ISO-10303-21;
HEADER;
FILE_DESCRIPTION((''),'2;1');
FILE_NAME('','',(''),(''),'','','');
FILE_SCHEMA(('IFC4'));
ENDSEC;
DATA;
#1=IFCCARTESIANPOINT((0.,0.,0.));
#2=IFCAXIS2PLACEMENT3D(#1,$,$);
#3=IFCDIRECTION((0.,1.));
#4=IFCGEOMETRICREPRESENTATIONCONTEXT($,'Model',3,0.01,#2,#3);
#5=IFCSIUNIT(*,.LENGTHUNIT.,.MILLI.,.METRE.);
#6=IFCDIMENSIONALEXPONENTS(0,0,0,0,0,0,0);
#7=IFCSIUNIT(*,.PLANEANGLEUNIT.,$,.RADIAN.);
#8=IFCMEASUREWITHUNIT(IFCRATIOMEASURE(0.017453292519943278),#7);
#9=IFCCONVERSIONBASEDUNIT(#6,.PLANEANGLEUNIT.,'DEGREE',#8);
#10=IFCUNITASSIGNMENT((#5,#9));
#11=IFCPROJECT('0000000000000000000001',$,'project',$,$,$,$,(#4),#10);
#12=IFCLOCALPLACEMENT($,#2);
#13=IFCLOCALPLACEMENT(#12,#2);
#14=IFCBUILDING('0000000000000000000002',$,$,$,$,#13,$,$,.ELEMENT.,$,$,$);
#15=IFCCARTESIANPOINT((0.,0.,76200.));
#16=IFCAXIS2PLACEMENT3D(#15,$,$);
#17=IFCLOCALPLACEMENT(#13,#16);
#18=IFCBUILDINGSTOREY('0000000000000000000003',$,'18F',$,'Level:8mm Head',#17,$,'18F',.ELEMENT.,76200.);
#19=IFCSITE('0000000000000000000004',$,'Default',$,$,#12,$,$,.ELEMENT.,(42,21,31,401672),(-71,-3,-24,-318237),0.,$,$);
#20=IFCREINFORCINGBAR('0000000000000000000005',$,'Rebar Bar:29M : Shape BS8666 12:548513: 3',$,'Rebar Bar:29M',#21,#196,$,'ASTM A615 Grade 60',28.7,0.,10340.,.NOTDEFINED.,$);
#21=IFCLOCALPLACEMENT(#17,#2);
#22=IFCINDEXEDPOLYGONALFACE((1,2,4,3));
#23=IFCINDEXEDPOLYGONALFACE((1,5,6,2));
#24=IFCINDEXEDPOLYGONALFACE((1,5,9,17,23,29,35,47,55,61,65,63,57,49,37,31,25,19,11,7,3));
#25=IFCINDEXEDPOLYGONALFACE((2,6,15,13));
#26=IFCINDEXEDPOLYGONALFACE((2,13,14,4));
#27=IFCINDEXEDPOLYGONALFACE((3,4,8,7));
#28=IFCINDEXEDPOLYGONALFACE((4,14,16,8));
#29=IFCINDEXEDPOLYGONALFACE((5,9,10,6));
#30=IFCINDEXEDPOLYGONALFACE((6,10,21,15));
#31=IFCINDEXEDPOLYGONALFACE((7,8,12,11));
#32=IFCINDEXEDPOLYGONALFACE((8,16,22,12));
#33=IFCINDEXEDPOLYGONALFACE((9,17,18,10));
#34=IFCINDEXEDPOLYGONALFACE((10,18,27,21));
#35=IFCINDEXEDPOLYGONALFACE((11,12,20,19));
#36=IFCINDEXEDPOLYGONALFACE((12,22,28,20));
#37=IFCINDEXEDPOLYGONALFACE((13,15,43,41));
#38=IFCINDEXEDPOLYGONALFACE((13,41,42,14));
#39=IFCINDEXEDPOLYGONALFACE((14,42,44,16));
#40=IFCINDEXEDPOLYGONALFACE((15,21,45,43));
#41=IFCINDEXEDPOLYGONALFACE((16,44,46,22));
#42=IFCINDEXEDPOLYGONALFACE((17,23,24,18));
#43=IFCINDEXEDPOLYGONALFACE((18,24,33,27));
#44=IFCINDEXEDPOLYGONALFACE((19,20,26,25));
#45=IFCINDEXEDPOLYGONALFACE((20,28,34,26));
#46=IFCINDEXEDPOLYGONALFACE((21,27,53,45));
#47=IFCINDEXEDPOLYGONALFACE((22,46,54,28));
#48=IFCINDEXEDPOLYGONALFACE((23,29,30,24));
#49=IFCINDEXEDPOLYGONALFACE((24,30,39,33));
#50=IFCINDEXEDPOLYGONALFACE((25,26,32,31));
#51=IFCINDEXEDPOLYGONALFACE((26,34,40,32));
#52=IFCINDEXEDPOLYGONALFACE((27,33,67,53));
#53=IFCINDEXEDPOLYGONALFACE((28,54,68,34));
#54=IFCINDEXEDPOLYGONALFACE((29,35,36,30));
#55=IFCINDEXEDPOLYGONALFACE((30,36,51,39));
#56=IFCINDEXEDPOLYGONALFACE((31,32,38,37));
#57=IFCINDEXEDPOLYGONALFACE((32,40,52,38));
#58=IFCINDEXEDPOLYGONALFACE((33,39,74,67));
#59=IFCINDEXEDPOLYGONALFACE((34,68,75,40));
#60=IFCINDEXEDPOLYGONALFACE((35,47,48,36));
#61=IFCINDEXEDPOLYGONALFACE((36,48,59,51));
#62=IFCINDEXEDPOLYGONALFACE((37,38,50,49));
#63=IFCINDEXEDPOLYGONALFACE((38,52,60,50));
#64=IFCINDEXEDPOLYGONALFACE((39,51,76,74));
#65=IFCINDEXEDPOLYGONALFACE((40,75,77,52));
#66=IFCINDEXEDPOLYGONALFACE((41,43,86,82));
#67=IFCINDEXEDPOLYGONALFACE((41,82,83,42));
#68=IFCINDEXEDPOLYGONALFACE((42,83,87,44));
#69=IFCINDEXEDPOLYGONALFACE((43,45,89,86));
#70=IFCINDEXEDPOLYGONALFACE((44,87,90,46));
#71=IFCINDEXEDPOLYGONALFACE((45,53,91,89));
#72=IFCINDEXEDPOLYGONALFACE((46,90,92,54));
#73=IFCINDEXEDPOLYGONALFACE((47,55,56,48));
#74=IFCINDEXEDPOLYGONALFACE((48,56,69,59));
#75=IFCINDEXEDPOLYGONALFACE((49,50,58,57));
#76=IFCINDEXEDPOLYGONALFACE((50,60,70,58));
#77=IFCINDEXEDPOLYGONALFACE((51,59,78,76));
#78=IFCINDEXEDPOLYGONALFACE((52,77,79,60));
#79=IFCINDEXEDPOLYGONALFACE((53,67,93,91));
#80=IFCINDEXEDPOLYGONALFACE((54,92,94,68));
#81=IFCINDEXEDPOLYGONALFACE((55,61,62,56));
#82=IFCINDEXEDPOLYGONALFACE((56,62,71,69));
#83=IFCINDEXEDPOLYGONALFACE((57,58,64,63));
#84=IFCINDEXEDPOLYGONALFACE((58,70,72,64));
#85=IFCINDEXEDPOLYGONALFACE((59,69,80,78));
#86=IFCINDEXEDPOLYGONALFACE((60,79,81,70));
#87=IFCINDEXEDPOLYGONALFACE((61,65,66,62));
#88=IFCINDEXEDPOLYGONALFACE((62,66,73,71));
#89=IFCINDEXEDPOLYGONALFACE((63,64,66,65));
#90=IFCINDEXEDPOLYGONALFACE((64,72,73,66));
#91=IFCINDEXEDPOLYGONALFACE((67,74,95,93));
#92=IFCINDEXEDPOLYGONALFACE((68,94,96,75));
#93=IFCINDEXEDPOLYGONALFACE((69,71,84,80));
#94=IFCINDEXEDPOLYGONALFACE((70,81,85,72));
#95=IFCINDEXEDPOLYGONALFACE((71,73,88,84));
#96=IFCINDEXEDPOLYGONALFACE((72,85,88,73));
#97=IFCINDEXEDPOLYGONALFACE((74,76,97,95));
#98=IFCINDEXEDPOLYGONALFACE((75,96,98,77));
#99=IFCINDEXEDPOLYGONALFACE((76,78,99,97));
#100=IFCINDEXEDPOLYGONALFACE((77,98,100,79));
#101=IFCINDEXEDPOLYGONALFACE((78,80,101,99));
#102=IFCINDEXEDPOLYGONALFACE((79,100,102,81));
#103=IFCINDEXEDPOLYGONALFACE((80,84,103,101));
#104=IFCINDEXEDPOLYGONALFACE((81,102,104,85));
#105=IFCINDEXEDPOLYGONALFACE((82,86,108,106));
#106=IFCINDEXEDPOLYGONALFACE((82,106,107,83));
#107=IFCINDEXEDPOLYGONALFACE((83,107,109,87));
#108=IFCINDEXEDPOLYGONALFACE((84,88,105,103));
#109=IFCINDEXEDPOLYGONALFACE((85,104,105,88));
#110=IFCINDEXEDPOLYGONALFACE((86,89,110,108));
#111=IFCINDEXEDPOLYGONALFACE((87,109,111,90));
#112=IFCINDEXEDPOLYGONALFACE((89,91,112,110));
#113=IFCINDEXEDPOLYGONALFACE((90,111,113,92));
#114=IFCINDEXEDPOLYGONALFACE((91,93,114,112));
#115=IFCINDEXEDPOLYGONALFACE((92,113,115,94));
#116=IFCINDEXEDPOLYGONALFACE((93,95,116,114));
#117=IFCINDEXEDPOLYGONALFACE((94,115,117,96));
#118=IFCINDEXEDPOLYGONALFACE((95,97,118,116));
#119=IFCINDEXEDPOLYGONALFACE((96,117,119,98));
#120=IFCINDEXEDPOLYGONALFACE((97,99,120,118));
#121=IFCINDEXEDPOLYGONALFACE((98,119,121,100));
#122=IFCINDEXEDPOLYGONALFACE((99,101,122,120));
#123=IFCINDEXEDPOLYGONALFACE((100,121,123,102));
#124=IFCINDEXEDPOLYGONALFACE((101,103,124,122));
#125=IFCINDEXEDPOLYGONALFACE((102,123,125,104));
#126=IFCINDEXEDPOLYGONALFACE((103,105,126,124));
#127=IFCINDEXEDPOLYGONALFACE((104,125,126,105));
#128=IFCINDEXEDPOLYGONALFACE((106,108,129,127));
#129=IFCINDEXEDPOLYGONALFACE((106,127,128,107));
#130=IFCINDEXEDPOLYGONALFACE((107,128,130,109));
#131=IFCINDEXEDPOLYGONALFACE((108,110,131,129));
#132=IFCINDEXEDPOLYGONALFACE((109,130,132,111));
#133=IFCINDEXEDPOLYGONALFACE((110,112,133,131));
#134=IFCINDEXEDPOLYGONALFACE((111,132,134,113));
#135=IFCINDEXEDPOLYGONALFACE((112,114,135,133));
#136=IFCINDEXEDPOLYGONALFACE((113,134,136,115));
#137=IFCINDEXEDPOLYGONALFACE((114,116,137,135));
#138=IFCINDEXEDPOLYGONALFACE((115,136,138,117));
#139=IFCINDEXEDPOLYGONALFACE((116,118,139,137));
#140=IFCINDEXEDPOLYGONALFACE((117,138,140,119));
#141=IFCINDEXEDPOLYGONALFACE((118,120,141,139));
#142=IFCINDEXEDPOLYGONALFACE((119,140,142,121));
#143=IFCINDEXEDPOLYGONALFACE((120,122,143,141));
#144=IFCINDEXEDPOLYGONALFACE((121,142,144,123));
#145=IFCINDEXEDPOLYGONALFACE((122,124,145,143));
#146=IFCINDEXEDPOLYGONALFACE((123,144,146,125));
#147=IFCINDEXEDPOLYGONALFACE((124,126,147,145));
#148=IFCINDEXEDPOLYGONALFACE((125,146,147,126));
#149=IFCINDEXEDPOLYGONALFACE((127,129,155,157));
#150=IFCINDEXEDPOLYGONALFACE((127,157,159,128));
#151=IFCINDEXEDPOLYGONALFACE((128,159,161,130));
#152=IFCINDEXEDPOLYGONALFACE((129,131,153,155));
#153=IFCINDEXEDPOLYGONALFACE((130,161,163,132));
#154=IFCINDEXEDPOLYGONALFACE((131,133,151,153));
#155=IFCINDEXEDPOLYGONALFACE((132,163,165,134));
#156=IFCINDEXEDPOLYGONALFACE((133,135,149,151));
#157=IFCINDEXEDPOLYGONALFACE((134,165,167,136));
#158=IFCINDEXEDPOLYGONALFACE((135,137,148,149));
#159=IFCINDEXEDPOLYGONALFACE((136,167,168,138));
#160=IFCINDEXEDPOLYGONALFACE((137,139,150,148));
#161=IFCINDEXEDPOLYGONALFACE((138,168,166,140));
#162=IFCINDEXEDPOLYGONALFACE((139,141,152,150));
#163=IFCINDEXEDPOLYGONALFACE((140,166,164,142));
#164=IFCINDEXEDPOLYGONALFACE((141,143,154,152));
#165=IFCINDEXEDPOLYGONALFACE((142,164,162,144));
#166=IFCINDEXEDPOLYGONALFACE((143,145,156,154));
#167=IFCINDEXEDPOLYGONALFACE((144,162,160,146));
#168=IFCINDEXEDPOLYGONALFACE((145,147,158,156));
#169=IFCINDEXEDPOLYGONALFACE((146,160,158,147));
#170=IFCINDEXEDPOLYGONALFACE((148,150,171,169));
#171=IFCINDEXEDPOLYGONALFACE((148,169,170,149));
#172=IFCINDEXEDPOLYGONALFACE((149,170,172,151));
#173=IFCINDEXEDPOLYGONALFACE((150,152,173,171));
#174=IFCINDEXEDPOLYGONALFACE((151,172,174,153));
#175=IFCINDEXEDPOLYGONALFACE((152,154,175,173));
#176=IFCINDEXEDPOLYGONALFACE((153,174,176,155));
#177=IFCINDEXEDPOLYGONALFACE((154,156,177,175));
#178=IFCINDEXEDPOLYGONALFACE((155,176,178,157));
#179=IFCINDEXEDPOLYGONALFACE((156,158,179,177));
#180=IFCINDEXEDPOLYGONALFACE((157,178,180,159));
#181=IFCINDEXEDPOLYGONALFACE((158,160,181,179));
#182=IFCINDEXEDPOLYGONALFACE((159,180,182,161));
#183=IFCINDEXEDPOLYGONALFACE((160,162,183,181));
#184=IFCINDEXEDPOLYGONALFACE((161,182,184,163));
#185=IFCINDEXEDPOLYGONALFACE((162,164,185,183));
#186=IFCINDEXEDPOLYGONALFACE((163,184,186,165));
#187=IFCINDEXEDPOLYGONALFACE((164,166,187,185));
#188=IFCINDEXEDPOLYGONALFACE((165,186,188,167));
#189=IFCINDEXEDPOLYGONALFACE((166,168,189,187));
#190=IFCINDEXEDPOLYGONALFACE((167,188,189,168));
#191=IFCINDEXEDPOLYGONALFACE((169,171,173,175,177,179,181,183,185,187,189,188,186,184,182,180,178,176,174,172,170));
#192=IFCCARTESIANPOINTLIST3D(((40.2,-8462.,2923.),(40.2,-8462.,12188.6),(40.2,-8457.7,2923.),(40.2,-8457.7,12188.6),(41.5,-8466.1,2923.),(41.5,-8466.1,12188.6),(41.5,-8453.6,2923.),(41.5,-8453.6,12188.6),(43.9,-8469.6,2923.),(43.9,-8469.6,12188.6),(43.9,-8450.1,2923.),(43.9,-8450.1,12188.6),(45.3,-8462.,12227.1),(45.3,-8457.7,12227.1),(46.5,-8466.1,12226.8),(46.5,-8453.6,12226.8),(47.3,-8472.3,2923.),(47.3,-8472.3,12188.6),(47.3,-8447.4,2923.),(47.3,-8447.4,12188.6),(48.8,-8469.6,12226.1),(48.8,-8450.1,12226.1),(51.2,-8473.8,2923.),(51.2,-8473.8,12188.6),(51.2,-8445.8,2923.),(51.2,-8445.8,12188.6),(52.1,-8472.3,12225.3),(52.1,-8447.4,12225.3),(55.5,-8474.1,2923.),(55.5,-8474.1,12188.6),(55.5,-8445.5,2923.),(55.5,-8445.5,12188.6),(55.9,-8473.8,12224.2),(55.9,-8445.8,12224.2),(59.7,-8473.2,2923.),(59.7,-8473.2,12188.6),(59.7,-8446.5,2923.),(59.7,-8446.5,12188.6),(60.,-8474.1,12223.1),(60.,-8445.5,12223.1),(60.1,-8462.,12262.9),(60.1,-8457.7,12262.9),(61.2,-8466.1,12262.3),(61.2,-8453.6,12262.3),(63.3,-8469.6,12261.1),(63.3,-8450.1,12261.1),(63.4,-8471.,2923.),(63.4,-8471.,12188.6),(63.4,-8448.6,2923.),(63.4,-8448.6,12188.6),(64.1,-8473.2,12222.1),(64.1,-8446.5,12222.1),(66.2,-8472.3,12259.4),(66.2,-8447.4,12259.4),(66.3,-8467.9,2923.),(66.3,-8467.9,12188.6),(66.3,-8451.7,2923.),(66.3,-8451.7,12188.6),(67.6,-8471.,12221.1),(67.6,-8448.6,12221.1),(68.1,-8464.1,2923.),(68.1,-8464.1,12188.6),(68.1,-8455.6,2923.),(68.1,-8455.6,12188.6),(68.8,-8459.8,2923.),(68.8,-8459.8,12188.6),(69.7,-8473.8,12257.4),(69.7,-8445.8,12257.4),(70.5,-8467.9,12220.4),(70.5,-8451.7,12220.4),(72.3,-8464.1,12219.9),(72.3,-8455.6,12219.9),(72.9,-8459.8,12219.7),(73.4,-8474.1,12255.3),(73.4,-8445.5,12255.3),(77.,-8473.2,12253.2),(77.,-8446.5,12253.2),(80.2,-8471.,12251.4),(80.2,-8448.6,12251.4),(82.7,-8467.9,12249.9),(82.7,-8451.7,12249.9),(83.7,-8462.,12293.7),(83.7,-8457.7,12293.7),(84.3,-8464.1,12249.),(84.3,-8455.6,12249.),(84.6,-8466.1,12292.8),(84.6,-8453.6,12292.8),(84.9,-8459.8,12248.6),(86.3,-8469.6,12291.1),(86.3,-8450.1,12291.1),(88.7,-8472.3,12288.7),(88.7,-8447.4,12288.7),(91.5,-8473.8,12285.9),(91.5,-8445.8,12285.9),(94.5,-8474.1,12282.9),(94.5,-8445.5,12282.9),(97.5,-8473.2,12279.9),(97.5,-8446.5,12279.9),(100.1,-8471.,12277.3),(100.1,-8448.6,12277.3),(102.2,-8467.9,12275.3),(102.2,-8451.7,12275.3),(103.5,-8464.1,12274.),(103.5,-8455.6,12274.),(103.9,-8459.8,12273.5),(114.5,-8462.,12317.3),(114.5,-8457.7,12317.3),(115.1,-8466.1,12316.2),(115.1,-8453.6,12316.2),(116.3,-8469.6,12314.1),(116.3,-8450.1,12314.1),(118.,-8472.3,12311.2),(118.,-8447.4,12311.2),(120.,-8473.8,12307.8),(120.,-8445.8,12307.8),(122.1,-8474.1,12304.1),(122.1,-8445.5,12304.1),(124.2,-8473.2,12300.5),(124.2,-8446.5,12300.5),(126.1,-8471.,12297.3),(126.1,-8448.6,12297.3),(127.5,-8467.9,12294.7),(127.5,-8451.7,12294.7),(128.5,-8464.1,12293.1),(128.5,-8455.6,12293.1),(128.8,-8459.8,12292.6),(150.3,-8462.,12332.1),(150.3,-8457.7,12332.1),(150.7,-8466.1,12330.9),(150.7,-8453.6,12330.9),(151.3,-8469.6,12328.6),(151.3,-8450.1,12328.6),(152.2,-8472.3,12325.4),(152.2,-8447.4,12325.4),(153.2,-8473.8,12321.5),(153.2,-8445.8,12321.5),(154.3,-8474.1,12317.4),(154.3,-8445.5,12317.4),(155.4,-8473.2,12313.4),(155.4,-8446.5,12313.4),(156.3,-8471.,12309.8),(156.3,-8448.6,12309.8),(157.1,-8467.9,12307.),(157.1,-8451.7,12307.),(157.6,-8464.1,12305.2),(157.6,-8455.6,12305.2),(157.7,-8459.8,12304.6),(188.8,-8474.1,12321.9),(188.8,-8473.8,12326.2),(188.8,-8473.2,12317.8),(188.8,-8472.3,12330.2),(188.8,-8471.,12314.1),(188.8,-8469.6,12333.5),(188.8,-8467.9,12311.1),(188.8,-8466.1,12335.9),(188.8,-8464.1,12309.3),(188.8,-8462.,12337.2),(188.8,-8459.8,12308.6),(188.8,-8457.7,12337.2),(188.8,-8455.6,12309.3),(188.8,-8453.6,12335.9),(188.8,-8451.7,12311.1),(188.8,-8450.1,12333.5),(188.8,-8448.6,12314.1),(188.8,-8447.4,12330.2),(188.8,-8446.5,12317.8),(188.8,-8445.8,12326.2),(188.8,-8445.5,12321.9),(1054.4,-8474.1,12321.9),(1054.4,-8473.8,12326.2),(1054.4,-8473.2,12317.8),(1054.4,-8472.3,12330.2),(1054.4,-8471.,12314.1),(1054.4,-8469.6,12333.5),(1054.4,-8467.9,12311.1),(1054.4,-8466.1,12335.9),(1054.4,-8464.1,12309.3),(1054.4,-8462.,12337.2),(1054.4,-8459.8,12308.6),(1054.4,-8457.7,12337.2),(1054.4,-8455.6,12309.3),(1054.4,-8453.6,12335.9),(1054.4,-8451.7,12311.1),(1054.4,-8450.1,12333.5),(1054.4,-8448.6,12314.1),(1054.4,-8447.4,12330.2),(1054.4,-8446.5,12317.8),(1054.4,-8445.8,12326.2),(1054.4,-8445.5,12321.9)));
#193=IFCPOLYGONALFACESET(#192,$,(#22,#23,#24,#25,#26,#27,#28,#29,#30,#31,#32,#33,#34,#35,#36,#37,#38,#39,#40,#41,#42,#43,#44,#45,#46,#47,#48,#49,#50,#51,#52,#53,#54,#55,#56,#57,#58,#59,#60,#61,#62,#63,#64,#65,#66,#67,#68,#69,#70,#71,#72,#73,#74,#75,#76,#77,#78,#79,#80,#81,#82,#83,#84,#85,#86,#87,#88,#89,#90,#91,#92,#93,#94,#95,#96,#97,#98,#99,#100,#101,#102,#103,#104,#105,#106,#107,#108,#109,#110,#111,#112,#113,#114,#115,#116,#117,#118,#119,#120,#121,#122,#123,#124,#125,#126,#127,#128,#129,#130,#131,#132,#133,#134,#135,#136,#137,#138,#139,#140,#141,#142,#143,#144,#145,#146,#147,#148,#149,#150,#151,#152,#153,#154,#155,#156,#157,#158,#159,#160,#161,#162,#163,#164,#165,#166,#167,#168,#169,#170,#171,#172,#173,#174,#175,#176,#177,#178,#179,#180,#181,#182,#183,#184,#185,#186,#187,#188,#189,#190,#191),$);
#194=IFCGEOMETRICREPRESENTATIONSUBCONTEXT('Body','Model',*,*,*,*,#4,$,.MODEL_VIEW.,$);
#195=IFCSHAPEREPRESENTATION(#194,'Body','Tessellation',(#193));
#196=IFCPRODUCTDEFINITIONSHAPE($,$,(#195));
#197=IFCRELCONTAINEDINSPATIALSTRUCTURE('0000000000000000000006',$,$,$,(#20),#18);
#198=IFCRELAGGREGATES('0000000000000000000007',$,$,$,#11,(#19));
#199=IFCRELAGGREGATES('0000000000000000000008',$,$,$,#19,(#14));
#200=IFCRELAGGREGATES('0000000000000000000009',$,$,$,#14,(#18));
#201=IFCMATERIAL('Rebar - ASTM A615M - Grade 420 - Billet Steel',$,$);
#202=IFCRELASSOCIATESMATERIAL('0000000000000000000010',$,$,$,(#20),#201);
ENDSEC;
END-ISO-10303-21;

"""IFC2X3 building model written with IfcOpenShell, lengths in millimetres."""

from ifc_helpers import new_model, entity, si_unit, converted_unit, direction, frame, origin, place, context, subcontext, project, spatial, material, element, save


model = new_model("IFC2X3")

# Units and contexts
model_context = context("Model", 3, precision=0.01, world=origin(), true_north=direction((0.0, 1.0)))
body_context = subcontext(model_context, "Body", "Model", "MODEL_VIEW")
ifc_project = project(units=[si_unit("LENGTHUNIT", "METRE", prefix="MILLI"), converted_unit("PLANEANGLEUNIT", "DEGREE", entity("IfcRatioMeasure", 0.017453292519943278), si_unit("PLANEANGLEUNIT", "RADIAN"), dimensions=[0, 0, 0, 0, 0, 0, 0])], contexts=[model_context])

# Site, building, storey
site_placement = place(None, origin())
site = spatial("IfcSite", under=ifc_project, at=site_placement, Name="Default", CompositionType="ELEMENT", RefLatitude=(42, 21, 31, 401672), RefLongitude=(-71, -3, -24, -318237), RefElevation=0.0)
building_placement = place(site_placement, origin())
building = spatial("IfcBuilding", under=site, at=building_placement, CompositionType="ELEMENT")
storey_placement = place(building_placement, frame((0.0, 0.0, 76200.0)))
storey = spatial("IfcBuildingStorey", under=building, at=storey_placement, Name="18F", ObjectType="Level:8mm Head", LongName="18F", CompositionType="ELEMENT", Elevation=76200.0)

# Reinforcing bar
ifc_material_1 = material(Name="Rebar - ASTM A615M - Grade 420 - Billet Steel")
reinforcing_bar_1_placement = place(storey_placement, origin())
element("IfcReinforcingBar", 1, at=reinforcing_bar_1_placement, inside=storey, material=ifc_material_1, Name="Rebar Bar:29M : Shape BS8666 12:548513: 3", SteelGrade="ASTM A615 Grade 60", ObjectType="Rebar Bar:29M", BarLength=10340.0, BarRole="NOTDEFINED", CrossSectionArea=0.0, NominalDiameter=28.7, context=body_context, shape_type="AdvancedSweptSolid", body=[
    entity("IfcSweptDiskSolid", entity("IfcCompositeCurve", [entity("IfcCompositeCurveSegment", "CONTINUOUS", True, entity("IfcPolyline", [entity("IfcCartesianPoint", [54.4, -8459.8, 2923.0]), entity("IfcCartesianPoint", [54.4, -8459.8, 12188.6])])), entity("IfcCompositeCurveSegment", "CONTINUOUS", True, entity("IfcTrimmedCurve", entity("IfcCircle", entity("IfcAxis2Placement3D", entity("IfcCartesianPoint", [188.8, -8459.8, 12188.6]), entity("IfcDirection", [0.0, 1.0, 0.0]), entity("IfcDirection", [0.0, 0.0, 1.0])), 134.3), [entity("IfcParameterValue", 270.0)], [entity("IfcParameterValue", 360.0)], True, "PARAMETER")), entity("IfcCompositeCurveSegment", "CONTINUOUS", True, entity("IfcPolyline", [entity("IfcCartesianPoint", [188.8, -8459.8, 12323.0]), entity("IfcCartesianPoint", [1054.4, -8459.8, 12323.0])]))], False), 14.3, None, 0.0, 92.0),
])

save(model, "model.ifc")
